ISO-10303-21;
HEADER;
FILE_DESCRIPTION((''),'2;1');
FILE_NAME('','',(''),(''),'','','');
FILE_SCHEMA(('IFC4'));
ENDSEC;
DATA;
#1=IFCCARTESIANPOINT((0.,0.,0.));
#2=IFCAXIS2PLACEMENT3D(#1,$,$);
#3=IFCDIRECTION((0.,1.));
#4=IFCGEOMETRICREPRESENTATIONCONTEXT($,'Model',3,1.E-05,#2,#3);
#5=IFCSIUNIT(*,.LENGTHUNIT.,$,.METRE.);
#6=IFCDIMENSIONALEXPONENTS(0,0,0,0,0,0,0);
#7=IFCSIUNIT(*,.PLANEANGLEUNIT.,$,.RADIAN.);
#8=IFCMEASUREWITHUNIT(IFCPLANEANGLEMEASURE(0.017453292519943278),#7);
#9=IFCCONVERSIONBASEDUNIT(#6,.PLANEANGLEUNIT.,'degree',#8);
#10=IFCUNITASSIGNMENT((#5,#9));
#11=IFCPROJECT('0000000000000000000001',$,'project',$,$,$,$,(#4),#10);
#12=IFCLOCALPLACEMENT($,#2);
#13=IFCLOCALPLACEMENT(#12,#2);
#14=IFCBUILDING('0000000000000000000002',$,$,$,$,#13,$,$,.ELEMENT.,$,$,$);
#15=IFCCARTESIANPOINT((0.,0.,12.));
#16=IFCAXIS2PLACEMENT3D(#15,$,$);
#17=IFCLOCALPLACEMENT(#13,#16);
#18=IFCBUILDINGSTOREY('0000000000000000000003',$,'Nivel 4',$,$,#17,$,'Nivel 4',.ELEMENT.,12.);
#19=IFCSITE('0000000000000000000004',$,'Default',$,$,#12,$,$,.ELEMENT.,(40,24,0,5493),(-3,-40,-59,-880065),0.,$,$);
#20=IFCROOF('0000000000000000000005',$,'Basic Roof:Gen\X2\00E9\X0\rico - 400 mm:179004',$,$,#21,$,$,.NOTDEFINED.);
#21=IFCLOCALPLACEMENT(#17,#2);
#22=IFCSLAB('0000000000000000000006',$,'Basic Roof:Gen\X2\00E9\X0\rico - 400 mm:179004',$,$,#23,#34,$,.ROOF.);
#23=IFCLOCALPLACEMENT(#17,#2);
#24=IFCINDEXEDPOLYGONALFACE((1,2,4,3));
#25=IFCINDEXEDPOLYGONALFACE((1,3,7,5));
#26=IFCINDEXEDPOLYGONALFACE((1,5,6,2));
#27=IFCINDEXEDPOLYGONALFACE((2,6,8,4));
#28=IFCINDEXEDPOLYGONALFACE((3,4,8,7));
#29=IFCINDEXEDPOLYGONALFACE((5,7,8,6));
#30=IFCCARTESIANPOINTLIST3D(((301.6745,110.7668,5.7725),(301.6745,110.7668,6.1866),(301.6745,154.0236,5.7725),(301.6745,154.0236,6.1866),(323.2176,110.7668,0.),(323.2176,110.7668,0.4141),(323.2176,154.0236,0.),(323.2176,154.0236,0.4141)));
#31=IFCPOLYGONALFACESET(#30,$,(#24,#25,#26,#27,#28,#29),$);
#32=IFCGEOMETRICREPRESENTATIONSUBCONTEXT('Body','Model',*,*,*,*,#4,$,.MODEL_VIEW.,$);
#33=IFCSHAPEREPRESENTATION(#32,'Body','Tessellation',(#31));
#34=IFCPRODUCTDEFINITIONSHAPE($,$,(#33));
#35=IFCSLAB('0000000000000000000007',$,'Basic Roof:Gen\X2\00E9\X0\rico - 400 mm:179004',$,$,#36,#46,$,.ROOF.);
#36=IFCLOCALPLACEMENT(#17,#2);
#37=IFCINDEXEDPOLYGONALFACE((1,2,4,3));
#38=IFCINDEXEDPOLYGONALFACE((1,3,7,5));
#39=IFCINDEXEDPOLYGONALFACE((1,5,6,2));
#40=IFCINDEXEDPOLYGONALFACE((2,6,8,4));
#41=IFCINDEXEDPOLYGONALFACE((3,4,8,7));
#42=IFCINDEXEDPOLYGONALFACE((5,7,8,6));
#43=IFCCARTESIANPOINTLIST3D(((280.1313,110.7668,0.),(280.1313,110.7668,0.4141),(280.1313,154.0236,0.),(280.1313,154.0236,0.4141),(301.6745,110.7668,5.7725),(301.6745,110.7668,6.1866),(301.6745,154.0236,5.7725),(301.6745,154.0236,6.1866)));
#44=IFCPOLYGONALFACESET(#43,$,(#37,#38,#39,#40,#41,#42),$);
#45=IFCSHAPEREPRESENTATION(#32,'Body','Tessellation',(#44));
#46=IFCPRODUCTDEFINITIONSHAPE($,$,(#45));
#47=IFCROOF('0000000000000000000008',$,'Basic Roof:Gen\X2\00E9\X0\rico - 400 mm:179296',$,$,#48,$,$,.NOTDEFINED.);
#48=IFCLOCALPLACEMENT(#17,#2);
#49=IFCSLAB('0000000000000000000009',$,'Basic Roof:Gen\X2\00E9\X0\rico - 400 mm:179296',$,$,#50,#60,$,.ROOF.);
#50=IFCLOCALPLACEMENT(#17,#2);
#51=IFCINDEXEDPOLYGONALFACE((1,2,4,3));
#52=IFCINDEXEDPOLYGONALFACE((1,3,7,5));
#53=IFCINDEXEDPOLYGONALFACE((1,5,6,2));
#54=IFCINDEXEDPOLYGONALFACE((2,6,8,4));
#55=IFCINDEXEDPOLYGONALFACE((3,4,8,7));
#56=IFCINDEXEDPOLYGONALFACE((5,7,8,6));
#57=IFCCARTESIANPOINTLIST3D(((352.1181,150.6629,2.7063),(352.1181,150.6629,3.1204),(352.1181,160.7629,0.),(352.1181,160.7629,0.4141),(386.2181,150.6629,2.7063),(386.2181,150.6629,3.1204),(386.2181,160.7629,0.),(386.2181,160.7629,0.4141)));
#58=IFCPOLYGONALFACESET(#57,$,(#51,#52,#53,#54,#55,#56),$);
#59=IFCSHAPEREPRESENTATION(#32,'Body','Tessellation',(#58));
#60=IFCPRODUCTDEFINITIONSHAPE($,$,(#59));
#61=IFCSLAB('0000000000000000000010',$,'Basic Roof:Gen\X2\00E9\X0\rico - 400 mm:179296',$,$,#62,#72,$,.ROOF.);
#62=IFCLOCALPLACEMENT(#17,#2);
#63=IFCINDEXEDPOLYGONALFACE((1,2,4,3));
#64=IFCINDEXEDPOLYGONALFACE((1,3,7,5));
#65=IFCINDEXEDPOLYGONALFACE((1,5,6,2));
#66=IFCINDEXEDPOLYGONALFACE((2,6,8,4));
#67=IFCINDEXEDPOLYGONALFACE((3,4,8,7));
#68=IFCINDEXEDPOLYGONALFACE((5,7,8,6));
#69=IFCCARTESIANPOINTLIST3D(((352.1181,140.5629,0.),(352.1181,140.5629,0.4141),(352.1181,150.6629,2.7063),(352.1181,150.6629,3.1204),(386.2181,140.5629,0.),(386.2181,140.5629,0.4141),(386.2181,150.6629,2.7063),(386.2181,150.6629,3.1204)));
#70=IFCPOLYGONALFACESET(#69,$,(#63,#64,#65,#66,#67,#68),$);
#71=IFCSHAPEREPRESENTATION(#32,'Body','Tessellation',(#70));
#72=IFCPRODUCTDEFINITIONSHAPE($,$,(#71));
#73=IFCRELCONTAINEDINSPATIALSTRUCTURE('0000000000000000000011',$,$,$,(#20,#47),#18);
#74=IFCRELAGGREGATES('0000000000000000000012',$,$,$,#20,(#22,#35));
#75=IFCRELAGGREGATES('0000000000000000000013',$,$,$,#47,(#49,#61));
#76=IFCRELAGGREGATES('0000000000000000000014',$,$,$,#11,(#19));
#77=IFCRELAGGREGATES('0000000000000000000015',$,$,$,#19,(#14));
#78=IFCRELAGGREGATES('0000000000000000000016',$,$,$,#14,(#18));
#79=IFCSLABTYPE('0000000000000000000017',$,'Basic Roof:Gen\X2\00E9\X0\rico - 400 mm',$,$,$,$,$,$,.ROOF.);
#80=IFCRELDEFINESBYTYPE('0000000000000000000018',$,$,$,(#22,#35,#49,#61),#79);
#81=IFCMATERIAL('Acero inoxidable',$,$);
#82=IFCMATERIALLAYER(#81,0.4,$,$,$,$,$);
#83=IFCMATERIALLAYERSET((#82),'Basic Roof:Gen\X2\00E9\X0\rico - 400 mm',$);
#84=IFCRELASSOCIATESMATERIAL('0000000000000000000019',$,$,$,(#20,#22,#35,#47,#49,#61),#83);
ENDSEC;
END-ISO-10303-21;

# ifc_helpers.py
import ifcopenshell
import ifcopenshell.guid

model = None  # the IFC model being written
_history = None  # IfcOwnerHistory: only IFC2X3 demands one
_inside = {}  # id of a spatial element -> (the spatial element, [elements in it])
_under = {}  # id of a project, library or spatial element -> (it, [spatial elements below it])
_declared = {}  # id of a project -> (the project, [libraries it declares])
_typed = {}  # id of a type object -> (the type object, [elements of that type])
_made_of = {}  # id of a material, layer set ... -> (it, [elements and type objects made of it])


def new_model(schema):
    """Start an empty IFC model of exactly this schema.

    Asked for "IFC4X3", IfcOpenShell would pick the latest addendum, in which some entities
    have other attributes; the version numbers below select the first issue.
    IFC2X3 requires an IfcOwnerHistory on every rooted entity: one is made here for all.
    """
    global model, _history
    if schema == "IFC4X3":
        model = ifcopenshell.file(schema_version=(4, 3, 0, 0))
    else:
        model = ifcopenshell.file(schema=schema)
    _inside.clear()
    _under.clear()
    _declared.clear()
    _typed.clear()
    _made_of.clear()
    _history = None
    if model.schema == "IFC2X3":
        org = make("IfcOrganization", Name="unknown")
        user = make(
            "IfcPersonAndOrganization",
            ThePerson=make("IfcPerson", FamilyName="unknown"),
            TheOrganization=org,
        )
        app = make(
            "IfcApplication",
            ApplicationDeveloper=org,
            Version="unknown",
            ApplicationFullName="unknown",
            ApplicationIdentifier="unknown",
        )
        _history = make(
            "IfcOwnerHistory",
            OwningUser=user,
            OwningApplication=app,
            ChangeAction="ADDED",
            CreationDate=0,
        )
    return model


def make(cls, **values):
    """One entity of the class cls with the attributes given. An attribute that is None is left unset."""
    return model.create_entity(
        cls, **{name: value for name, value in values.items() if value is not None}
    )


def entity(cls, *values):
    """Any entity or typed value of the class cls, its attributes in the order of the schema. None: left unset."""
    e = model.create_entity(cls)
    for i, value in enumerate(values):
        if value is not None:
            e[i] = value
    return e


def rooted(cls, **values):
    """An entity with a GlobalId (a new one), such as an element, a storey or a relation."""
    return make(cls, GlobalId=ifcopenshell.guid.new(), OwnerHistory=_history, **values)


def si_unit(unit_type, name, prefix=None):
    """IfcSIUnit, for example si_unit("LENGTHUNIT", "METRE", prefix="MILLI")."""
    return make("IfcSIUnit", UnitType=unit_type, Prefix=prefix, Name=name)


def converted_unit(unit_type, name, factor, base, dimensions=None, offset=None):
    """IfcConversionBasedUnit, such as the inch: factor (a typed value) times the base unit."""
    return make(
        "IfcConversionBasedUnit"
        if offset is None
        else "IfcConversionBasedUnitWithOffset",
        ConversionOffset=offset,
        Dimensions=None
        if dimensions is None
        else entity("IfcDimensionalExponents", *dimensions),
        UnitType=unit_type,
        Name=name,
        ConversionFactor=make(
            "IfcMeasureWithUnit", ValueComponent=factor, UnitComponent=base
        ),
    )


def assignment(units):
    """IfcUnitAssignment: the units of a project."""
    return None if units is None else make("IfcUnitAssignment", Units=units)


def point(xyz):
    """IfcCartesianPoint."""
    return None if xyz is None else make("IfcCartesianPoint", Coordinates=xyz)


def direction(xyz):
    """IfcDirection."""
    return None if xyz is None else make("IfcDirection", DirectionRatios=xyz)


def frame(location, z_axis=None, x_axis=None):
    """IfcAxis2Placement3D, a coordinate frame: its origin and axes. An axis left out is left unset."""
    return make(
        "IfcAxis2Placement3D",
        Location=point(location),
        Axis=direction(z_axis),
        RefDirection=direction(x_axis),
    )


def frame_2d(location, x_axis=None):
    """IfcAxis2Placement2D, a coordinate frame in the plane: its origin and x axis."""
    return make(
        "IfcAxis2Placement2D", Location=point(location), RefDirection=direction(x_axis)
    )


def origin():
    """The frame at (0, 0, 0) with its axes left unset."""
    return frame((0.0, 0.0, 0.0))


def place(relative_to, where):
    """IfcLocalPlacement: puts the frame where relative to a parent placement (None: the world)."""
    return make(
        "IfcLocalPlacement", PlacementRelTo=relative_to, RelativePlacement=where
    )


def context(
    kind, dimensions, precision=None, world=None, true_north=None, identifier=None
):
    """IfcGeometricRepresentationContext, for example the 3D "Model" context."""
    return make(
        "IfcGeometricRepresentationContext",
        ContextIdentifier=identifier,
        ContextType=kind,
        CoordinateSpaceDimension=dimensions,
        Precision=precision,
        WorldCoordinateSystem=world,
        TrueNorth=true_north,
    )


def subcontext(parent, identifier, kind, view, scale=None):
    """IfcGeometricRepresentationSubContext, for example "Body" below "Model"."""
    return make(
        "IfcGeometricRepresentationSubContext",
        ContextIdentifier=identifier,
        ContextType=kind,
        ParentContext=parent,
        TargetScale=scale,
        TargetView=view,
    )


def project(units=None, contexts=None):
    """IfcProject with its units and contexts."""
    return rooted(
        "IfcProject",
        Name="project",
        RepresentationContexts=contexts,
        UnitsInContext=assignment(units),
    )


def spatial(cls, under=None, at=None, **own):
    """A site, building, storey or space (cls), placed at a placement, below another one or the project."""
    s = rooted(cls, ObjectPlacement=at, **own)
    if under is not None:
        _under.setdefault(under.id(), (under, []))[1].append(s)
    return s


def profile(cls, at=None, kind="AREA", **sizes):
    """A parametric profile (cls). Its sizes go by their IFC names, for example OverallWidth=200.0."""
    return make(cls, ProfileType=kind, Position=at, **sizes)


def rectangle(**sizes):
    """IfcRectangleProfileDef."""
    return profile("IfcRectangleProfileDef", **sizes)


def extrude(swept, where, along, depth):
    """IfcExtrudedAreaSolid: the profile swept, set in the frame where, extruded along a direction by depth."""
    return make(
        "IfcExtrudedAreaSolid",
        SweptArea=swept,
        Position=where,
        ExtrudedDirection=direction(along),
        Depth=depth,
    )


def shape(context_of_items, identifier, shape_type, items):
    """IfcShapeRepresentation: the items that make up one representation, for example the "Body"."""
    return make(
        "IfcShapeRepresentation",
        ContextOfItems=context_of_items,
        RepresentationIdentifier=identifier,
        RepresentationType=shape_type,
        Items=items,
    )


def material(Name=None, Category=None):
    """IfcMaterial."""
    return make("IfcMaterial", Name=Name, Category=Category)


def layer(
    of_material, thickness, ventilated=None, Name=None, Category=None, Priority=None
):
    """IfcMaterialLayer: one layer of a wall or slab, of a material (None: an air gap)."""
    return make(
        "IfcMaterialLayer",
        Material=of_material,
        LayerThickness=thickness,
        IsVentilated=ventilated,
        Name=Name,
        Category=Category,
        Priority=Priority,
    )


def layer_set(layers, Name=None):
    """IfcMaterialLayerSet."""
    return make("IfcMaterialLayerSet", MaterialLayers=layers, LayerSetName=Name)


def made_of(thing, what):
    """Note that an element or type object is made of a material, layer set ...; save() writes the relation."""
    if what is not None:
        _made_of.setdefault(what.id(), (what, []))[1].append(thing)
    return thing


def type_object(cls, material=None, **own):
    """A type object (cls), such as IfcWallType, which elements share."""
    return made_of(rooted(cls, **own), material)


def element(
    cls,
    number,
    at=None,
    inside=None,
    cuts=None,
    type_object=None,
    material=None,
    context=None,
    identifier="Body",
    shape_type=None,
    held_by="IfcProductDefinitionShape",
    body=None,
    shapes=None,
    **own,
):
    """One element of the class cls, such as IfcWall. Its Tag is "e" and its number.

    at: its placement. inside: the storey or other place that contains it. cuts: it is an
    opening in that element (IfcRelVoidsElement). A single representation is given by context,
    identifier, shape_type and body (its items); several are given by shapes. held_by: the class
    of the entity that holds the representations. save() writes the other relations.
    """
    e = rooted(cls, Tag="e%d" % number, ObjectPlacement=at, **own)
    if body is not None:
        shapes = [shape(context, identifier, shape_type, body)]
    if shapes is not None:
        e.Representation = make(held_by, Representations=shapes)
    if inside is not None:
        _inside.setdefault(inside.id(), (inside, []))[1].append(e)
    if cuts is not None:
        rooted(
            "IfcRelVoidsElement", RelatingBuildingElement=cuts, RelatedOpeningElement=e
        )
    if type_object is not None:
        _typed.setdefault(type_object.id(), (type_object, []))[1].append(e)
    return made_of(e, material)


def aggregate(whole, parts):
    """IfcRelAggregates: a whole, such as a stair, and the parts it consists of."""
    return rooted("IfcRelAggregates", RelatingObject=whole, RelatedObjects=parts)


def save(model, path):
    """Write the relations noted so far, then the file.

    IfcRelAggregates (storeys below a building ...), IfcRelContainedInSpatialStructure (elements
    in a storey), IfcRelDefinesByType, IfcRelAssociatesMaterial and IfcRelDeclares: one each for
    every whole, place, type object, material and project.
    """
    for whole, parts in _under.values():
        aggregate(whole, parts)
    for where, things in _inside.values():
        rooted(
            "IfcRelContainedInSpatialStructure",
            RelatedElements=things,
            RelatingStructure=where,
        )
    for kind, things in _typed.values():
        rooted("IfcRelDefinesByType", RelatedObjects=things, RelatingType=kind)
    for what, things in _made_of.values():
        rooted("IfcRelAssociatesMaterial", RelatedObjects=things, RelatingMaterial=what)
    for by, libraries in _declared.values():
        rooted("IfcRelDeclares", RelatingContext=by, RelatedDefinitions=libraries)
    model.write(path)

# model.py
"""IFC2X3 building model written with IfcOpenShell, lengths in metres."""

from ifc_helpers import new_model, entity, si_unit, converted_unit, direction, frame, frame_2d, origin, place, context, subcontext, project, spatial, rectangle, extrude, material, layer, layer_set, type_object, element, aggregate, save


model = new_model("IFC2X3")

# Units and contexts
model_context = context("Model", 3, precision=1e-05, world=origin(), true_north=direction((0.0, 1.0)))
body_context = subcontext(model_context, "Body", "Model", "MODEL_VIEW")
ifc_project = project(units=[si_unit("LENGTHUNIT", "METRE"), converted_unit("PLANEANGLEUNIT", "degree", entity("IfcPlaneAngleMeasure", 0.017453292519943278), si_unit("PLANEANGLEUNIT", "RADIAN"), dimensions=[0, 0, 0, 0, 0, 0, 0])], contexts=[model_context])

# Site, building, storey
site_placement = place(None, origin())
site = spatial("IfcSite", under=ifc_project, at=site_placement, Name="Default", CompositionType="ELEMENT", RefLatitude=(40, 24, 0, 5493), RefLongitude=(-3, -40, -59, -880065), RefElevation=0.0)
building_placement = place(site_placement, origin())
building = spatial("IfcBuilding", under=site, at=building_placement, CompositionType="ELEMENT")
storey_placement = place(building_placement, frame((0.0, 0.0, 12.0)))
storey = spatial("IfcBuildingStorey", under=building, at=storey_placement, Name="Nivel 4", LongName="Nivel 4", CompositionType="ELEMENT", Elevation=12.0)

# Roofs, slabs
ifc_material = material(Name="Acero inoxidable")
ifc_layer = layer(ifc_material, 0.4)
ifc_layer_set = layer_set([ifc_layer], Name="Basic Roof:Genérico - 400 mm")
slab_type = type_object("IfcSlabType", Name="Basic Roof:Genérico - 400 mm", PredefinedType="ROOF")
roof_1_placement = place(storey_placement, frame((280.1313, 110.7668, 0.0)))
roof_1 = element("IfcRoof", 1, at=roof_1_placement, inside=storey, material=ifc_layer_set, Name="Basic Roof:Genérico - 400 mm:179004", ShapeType="NOTDEFINED")
slab_1_placement = place(roof_1_placement, origin())
slab_1 = element("IfcSlab", 2, at=slab_1_placement, type_object=slab_type, material=ifc_layer_set, Name="Basic Roof:Genérico - 400 mm:179004", PredefinedType="ROOF", context=body_context, shape_type="SweptSolid", body=[
    extrude(rectangle(XDim=22.3031, YDim=43.2569, at=frame_2d((0.0, 0.0), x_axis=(1.0, 0.0))), frame((32.3147, 21.6284, 2.8862), z_axis=(0.258819, 0.0, 0.965926), x_axis=(0.965926, 0.0, -0.258819)), (-0.258819, 0.0, 0.965926), 0.4141),
])
slab_2_placement = place(roof_1_placement, origin())
slab_2 = element("IfcSlab", 3, at=slab_2_placement, type_object=slab_type, material=ifc_layer_set, Name="Basic Roof:Genérico - 400 mm:179004", PredefinedType="ROOF", context=body_context, shape_type="SweptSolid", body=[
    extrude(rectangle(XDim=43.2569, YDim=22.3031, at=frame_2d((0.0, 0.0), x_axis=(0.0, 1.0))), frame((10.7716, 21.6284, 2.8862), z_axis=(-0.258819, 0.0, 0.965926), x_axis=(0.965926, 0.0, 0.258819)), (0.258819, 0.0, 0.965926), 0.4141),
])
aggregate(roof_1, [slab_1, slab_2])
roof_2_placement = place(storey_placement, frame((352.1181, 140.5629, 0.0)))
roof_2 = element("IfcRoof", 4, at=roof_2_placement, inside=storey, material=ifc_layer_set, Name="Basic Roof:Genérico - 400 mm:179296", ShapeType="NOTDEFINED")
slab_3_placement = place(roof_2_placement, origin())
slab_3 = element("IfcSlab", 5, at=slab_3_placement, type_object=slab_type, material=ifc_layer_set, Name="Basic Roof:Genérico - 400 mm:179296", PredefinedType="ROOF", context=body_context, shape_type="SweptSolid", body=[
    extrude(rectangle(XDim=10.4563, YDim=34.1, at=frame_2d((0.0, 0.0), x_axis=(0.0, -1.0))), frame((17.05, 15.15, 1.3531), z_axis=(0.0, 0.258819, 0.965926), x_axis=(1.0, 0.0, 0.0)), (0.0, -0.258819, 0.965926), 0.4141),
])
slab_4_placement = place(roof_2_placement, origin())
slab_4 = element("IfcSlab", 6, at=slab_4_placement, type_object=slab_type, material=ifc_layer_set, Name="Basic Roof:Genérico - 400 mm:179296", PredefinedType="ROOF", context=body_context, shape_type="SweptSolid", body=[
    extrude(rectangle(XDim=34.1, YDim=10.4563, at=frame_2d((0.0, 0.0), x_axis=(-1.0, 0.0))), frame((17.05, 5.05, 1.3531), z_axis=(0.0, -0.258819, 0.965926), x_axis=(1.0, 0.0, 0.0)), (0.0, 0.258819, 0.965926), 0.4141),
])
aggregate(roof_2, [slab_3, slab_4])

save(model, "model.ifc")
